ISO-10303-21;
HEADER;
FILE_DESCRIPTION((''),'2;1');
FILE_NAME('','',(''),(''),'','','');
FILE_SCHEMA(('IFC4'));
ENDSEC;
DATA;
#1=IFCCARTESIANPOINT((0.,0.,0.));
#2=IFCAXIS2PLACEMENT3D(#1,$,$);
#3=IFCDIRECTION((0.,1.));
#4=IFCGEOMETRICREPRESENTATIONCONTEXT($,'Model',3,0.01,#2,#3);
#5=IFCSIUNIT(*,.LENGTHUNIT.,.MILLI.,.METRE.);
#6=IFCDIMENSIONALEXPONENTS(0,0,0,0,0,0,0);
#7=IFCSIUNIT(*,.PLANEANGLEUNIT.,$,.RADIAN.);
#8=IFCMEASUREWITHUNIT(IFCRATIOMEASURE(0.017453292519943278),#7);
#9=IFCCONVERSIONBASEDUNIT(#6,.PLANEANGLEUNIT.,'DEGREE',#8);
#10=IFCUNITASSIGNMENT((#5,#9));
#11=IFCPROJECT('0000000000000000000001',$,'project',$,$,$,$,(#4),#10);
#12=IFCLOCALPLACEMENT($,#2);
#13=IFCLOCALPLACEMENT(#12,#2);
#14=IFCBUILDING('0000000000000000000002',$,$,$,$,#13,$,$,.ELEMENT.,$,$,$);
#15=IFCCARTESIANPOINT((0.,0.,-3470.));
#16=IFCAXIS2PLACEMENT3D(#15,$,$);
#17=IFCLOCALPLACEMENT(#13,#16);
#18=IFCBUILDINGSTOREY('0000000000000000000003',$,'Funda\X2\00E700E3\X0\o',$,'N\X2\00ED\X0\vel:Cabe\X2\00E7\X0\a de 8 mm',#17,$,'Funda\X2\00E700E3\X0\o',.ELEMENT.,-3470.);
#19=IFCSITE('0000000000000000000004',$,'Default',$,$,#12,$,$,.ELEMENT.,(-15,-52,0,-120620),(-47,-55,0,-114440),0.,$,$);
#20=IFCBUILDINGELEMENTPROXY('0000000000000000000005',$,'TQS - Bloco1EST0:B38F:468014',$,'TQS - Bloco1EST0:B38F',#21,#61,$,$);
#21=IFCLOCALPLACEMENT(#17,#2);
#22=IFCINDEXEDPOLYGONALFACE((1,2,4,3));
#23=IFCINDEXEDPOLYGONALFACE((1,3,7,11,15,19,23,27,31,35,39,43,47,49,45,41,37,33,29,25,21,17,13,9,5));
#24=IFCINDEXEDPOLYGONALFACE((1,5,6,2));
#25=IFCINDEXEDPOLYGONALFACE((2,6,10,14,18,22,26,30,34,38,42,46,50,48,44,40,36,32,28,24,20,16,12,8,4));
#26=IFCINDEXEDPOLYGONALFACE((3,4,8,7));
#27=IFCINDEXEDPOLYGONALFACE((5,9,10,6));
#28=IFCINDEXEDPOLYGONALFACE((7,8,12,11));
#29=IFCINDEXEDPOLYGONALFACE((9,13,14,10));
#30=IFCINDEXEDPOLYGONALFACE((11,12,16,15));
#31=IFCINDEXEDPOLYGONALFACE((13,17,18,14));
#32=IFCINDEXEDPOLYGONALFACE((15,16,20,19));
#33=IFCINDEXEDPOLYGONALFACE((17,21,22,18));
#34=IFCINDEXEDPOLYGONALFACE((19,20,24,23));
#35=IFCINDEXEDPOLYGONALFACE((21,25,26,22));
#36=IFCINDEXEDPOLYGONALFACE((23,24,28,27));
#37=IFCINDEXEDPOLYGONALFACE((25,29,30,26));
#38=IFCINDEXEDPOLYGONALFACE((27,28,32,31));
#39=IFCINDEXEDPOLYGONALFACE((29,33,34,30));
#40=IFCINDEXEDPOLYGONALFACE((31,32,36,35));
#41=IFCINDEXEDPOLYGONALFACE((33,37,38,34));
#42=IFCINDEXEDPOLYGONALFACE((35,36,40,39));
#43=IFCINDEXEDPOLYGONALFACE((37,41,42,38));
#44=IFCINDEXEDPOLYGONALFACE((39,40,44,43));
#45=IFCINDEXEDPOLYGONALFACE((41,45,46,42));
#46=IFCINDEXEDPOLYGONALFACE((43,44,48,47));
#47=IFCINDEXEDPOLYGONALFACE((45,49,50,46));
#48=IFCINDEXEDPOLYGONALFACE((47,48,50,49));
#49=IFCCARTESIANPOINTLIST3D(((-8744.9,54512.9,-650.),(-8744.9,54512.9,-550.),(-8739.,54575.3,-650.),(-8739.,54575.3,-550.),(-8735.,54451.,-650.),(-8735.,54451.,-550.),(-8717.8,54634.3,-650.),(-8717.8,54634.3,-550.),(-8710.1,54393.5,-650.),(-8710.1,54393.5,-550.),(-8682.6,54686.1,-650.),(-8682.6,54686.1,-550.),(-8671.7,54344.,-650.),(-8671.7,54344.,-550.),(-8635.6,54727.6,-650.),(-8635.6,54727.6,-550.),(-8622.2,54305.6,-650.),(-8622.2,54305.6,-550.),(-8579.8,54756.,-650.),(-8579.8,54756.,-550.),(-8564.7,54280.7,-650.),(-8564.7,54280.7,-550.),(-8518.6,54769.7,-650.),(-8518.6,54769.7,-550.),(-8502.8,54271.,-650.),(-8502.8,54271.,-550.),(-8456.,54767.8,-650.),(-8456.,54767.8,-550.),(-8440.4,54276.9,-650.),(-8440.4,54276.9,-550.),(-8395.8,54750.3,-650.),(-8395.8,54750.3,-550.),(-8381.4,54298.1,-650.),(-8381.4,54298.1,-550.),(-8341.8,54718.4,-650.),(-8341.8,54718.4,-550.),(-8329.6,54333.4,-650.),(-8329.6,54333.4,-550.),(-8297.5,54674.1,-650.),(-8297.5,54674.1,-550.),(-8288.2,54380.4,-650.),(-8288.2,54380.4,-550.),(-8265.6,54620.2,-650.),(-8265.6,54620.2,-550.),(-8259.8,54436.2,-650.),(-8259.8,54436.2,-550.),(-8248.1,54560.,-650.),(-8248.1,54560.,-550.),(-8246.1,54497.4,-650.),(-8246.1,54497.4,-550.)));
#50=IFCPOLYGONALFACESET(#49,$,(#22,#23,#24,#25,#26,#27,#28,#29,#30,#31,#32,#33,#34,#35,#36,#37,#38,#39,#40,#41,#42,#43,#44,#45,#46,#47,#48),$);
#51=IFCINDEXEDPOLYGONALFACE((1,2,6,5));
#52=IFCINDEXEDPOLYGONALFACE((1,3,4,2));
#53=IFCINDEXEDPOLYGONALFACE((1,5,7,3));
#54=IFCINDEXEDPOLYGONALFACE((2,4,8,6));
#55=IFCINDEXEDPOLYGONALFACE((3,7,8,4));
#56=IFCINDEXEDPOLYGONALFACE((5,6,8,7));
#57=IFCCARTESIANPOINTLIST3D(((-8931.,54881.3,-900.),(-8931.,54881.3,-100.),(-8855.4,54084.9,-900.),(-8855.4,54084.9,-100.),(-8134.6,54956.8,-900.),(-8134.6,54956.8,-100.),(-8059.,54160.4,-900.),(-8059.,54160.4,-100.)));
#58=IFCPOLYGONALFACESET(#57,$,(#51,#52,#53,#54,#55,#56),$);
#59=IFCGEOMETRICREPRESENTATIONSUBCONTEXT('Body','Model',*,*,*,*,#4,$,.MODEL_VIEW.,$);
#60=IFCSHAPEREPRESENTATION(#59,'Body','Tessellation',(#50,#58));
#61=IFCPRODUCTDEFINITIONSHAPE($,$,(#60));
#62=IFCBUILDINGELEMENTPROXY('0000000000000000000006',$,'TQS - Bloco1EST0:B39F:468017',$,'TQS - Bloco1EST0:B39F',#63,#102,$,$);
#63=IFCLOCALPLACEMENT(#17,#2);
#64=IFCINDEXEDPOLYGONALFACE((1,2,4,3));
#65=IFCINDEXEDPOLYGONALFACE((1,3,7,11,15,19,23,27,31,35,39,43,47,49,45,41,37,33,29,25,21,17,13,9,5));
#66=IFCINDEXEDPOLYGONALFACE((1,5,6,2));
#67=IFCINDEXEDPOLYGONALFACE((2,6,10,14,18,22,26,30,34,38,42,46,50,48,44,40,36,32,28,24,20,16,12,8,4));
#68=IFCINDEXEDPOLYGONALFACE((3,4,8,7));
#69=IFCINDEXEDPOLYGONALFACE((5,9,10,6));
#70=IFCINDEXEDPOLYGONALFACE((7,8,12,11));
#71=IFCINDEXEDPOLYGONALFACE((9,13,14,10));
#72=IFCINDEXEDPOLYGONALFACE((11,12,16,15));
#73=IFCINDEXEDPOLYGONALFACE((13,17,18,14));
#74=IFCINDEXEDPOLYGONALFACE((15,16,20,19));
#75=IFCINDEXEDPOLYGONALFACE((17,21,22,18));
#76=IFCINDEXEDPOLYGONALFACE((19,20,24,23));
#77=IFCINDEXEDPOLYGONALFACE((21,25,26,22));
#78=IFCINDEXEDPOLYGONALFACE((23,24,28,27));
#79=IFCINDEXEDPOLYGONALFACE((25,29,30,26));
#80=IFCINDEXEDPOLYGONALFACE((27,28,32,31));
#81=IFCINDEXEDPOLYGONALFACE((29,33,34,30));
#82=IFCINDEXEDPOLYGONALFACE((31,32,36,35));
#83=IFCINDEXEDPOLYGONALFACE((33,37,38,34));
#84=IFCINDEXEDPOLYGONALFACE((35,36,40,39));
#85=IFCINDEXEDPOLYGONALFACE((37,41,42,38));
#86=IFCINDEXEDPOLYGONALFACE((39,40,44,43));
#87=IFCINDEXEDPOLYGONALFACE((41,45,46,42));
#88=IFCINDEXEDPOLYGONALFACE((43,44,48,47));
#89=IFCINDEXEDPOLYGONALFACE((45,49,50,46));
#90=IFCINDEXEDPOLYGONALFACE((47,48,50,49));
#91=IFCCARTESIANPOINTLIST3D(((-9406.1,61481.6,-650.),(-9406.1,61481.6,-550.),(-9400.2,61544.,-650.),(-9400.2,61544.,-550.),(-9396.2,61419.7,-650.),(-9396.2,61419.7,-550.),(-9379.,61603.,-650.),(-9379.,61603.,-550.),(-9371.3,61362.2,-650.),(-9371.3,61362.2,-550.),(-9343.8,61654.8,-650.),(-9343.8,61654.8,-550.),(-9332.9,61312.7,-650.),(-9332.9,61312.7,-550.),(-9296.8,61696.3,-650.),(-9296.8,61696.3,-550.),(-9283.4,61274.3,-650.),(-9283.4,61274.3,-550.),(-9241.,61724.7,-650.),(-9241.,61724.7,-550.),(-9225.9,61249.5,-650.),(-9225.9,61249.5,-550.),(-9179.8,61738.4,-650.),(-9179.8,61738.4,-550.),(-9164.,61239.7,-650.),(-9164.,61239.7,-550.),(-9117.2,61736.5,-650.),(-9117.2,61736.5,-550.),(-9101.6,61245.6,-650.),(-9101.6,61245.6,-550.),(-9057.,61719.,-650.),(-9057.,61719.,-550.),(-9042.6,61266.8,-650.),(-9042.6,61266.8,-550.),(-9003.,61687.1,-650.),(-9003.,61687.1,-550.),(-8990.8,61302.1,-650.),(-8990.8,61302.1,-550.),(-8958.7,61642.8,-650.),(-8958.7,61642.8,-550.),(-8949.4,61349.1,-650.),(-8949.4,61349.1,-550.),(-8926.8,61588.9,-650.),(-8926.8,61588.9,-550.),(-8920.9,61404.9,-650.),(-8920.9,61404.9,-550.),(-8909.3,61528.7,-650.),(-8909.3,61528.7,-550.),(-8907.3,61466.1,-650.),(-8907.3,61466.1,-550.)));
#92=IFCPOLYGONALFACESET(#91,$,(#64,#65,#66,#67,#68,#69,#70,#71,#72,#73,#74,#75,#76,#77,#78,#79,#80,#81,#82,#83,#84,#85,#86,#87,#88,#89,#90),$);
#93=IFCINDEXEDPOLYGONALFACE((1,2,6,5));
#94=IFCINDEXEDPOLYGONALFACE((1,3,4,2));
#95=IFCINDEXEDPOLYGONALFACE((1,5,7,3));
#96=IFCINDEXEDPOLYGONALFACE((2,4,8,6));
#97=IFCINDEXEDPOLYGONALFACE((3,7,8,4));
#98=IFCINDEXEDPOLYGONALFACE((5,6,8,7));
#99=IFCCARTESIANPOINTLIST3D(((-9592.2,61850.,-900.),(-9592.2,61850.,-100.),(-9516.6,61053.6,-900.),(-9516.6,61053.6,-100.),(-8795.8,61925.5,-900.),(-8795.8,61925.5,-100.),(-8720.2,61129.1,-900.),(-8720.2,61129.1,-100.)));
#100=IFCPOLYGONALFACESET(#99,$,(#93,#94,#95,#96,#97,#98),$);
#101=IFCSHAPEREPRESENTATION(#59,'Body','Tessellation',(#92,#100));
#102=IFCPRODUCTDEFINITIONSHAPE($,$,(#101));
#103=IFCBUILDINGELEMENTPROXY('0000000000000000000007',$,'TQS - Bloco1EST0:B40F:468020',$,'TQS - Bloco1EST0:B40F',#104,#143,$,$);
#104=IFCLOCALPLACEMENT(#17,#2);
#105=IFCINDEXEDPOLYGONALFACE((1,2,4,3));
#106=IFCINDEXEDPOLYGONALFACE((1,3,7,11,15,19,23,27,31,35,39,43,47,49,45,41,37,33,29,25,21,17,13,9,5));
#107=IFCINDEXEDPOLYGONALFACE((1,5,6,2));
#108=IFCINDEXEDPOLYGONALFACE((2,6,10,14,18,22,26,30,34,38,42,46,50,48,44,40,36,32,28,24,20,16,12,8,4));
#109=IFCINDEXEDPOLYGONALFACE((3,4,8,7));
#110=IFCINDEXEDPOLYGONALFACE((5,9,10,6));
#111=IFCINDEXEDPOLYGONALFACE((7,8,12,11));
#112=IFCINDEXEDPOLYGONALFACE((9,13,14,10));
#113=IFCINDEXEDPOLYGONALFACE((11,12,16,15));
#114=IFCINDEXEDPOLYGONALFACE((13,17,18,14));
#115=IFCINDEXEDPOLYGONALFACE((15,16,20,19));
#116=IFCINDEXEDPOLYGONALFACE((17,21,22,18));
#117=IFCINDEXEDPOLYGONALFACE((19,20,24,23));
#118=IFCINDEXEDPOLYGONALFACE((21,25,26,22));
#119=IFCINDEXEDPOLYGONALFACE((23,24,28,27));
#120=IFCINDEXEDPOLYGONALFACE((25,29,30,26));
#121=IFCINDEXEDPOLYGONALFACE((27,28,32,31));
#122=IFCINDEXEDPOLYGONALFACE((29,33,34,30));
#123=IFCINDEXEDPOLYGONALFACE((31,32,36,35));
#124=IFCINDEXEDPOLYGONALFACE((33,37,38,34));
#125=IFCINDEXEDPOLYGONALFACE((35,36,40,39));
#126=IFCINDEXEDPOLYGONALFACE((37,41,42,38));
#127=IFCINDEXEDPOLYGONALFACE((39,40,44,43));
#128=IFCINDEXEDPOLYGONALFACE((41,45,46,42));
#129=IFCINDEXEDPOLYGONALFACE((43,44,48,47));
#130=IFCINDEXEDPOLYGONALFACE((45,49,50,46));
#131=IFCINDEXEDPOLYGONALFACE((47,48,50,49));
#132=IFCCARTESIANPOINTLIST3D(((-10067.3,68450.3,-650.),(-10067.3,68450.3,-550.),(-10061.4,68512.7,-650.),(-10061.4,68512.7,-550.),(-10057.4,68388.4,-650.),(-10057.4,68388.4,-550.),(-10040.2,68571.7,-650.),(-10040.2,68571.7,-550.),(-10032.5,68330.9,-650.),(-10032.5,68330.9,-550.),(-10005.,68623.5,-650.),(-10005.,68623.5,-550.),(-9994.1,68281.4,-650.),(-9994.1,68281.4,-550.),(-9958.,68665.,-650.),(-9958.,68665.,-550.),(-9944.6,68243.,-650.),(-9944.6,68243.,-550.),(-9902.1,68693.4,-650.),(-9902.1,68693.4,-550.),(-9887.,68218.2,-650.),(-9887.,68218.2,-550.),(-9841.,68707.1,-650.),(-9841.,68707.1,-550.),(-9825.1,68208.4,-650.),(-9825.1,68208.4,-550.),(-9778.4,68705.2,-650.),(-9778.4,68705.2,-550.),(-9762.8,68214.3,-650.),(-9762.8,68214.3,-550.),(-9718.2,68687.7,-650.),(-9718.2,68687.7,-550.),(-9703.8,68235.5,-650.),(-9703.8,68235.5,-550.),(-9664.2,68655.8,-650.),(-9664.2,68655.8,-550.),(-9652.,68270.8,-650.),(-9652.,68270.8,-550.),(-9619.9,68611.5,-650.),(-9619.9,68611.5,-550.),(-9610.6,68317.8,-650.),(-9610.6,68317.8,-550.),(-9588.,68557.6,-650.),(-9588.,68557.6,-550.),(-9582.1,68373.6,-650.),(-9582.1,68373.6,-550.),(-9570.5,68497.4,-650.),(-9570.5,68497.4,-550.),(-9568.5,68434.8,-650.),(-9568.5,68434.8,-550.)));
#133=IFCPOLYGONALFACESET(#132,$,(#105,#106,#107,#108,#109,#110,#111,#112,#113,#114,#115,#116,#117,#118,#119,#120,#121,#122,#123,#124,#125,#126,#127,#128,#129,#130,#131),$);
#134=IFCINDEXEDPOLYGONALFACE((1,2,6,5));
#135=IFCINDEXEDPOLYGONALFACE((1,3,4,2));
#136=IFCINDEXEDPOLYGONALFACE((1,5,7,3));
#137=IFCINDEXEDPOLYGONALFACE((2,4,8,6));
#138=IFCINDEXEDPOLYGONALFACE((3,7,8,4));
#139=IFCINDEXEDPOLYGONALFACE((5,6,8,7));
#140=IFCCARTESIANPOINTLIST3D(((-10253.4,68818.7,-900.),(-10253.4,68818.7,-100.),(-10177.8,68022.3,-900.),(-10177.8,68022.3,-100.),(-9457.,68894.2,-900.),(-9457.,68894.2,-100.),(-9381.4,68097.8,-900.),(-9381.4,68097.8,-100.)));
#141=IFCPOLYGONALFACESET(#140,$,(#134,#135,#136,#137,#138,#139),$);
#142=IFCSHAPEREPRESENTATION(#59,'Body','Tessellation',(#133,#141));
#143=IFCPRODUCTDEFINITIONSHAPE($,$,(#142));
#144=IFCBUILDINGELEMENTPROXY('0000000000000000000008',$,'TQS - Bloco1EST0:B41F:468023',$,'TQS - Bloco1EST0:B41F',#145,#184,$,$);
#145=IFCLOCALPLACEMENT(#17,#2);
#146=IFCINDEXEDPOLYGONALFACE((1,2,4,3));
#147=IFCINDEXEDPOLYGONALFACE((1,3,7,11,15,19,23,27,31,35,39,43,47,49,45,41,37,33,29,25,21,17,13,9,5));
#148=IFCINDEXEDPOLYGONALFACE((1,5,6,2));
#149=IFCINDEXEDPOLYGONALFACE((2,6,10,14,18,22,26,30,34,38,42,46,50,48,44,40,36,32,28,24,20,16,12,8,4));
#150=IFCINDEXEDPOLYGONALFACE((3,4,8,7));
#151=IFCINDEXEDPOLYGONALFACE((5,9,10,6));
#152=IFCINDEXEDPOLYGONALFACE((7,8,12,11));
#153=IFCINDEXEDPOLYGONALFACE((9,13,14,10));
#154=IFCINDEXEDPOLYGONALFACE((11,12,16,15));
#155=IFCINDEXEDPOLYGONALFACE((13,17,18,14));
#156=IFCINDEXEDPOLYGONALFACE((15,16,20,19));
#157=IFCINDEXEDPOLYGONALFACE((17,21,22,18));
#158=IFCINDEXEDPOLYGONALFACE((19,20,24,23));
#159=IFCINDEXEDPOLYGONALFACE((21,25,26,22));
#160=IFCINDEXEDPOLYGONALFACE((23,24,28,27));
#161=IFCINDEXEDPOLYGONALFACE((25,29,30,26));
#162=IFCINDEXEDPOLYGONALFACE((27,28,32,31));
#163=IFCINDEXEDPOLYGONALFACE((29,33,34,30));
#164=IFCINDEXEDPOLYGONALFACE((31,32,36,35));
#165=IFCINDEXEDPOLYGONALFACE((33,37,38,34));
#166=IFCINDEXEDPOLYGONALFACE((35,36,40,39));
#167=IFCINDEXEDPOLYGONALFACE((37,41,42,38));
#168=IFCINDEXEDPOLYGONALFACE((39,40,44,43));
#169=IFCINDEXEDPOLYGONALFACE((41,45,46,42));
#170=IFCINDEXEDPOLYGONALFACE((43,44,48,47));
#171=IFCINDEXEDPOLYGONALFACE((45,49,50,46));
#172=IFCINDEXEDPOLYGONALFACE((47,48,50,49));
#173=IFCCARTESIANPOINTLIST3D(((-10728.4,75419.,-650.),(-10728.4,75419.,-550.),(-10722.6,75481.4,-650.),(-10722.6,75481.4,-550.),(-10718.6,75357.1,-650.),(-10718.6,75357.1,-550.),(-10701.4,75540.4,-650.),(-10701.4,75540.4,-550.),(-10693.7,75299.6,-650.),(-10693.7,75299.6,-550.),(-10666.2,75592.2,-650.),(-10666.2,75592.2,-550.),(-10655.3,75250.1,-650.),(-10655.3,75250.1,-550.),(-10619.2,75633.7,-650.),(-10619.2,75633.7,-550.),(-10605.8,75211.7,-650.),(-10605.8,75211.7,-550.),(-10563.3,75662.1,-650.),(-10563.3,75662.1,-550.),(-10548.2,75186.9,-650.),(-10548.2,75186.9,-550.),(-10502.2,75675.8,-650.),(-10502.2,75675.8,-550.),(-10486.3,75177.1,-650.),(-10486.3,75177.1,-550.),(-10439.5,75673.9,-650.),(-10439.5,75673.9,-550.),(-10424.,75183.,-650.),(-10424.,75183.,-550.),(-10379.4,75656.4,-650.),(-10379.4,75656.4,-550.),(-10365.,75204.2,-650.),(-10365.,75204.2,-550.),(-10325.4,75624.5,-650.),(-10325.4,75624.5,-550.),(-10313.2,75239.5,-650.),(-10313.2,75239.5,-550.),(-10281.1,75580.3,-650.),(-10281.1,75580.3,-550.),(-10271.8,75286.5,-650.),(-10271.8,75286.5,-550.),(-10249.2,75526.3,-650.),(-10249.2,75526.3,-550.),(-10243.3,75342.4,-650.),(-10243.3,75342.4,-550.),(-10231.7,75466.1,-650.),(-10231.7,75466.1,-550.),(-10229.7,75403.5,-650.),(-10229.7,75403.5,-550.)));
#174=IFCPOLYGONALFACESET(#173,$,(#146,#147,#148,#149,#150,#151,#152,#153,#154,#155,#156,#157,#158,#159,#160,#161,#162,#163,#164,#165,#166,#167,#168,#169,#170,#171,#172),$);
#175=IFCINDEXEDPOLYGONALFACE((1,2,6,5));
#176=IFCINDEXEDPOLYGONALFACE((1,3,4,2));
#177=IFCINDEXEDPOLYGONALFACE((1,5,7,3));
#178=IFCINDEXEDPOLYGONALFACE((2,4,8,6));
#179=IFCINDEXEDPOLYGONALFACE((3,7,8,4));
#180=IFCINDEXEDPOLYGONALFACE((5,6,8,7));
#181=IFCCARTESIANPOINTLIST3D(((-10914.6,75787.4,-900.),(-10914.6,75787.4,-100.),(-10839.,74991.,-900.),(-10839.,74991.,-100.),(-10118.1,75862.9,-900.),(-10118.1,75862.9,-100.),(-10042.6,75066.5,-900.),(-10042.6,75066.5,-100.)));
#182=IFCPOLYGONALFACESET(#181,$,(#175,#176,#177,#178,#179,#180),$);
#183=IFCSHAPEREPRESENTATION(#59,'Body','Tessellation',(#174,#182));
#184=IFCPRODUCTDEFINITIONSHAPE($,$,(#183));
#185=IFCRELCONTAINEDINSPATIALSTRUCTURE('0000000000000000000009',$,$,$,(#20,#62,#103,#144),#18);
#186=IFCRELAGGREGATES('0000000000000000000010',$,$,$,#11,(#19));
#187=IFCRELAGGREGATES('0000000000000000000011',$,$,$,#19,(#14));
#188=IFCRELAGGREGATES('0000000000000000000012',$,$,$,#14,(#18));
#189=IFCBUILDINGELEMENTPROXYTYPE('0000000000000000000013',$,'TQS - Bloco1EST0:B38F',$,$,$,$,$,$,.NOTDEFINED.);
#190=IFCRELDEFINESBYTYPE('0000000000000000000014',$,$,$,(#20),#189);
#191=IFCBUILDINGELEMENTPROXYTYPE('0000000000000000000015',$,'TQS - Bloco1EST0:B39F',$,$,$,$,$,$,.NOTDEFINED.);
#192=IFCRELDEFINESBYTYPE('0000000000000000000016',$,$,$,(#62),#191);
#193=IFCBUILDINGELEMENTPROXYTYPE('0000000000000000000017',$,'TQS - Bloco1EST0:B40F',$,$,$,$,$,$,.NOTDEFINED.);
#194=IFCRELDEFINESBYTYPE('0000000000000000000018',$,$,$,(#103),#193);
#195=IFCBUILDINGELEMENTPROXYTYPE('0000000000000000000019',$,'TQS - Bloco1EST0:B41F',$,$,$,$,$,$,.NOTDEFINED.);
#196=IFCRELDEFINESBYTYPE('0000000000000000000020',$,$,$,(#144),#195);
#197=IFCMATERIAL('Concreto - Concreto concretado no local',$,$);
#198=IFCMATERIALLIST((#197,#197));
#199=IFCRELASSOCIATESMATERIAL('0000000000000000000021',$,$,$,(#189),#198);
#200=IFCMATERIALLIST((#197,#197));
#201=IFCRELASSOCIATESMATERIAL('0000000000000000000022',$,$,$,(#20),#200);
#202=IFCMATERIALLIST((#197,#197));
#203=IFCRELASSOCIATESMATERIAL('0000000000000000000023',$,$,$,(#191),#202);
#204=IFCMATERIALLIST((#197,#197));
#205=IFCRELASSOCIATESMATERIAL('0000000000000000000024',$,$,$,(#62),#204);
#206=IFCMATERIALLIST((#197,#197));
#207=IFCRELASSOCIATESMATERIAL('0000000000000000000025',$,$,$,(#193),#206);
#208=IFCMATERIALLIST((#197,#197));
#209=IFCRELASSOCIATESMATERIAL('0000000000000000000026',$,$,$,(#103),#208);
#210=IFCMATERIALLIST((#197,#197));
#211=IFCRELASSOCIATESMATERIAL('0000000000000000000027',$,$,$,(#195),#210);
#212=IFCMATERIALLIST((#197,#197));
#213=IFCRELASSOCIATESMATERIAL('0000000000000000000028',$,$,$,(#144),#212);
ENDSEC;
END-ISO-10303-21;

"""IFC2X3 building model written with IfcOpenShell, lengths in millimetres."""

from ifc_helpers import new_model, entity, si_unit, converted_unit, direction, frame, frame_2d, origin, origin_2d_with_axis, place, context, subcontext, project, spatial, rectangle, circle, extrude, source, transform, mapped, material, material_list, type_object, type_shapes, element, save


model = new_model("IFC2X3")

# Units and contexts
model_context = context("Model", 3, precision=0.01, world=origin(), true_north=direction((0.0, 1.0)))
body_context = subcontext(model_context, "Body", "Model", "MODEL_VIEW")
ifc_project = project(units=[si_unit("LENGTHUNIT", "METRE", prefix="MILLI"), converted_unit("PLANEANGLEUNIT", "DEGREE", entity("IfcRatioMeasure", 0.017453292519943278), si_unit("PLANEANGLEUNIT", "RADIAN"), dimensions=[0, 0, 0, 0, 0, 0, 0])], contexts=[model_context])

# Site, building, storey
site_placement = place(None, origin())
site = spatial("IfcSite", under=ifc_project, at=site_placement, Name="Default", CompositionType="ELEMENT", RefLatitude=(-15, -52, 0, -120620), RefLongitude=(-47, -55, 0, -114440), RefElevation=0.0)
building_placement = place(site_placement, origin())
building = spatial("IfcBuilding", under=site, at=building_placement, CompositionType="ELEMENT")
storey_placement = place(building_placement, frame((0.0, 0.0, -3470.0)))
storey = spatial("IfcBuildingStorey", under=building, at=storey_placement, Name="Fundação", ObjectType="Nível:Cabeça de 8 mm", LongName="Fundação", CompositionType="ELEMENT", Elevation=-3470.0)

# Building element proxies
ifc_material_1 = material(Name="Concreto - Concreto concretado no local")
ifc_material_list_1 = material_list([ifc_material_1, ifc_material_1])
ifc_material_list_2 = material_list([ifc_material_1, ifc_material_1])
building_element_proxy_type_1 = type_object("IfcBuildingElementProxyType", Name="TQS - Bloco1EST0:B38F", PredefinedType="NOTDEFINED", material=ifc_material_list_2)
shared_shape_1 = source(origin(), body_context, "Body", "SweptSolid", [
    extrude(circle(Radius=250.0, at=frame_2d((0.0, 0.0), x_axis=(1.0, 0.0))), frame((0.0, 0.0, -550.0)), (0.0, 0.0, 1.0), 100.0),
    extrude(rectangle(XDim=800.0, YDim=800.0, at=origin_2d_with_axis()), frame((0.0, 0.0, -800.0), z_axis=(0.0, 0.0, 1.0), x_axis=(-1.0, 0.0, 0.0)), (0.0, 0.0, 1.0), 800.0),
])
type_shapes(building_element_proxy_type_1, [shared_shape_1])
proxy_1_placement = place(storey_placement, frame((-8495.0, 54520.8, -100.0), z_axis=(0.0, 0.0, 1.0), x_axis=(-0.094456, 0.995529, 0.0)))
element("IfcBuildingElementProxy", 1, at=proxy_1_placement, inside=storey, type_object=building_element_proxy_type_1, material=ifc_material_list_1, Name="TQS - Bloco1EST0:B38F:468014", ObjectType="TQS - Bloco1EST0:B38F", context=body_context, shape_type="MappedRepresentation", body=[
    mapped(shared_shape_1, transform((0.0, 0.0, 0.0), scale=1.0)),
])
ifc_material_list_3 = material_list([ifc_material_1, ifc_material_1])
ifc_material_list_4 = material_list([ifc_material_1, ifc_material_1])
building_element_proxy_type_2 = type_object("IfcBuildingElementProxyType", Name="TQS - Bloco1EST0:B39F", PredefinedType="NOTDEFINED", material=ifc_material_list_4)
shared_shape_2 = source(origin(), body_context, "Body", "SweptSolid", [
    extrude(circle(Radius=250.0, at=frame_2d((0.0, 0.0), x_axis=(1.0, 0.0))), frame((0.0, 0.0, -550.0)), (0.0, 0.0, 1.0), 100.0),
    extrude(rectangle(XDim=800.0, YDim=800.0, at=origin_2d_with_axis()), frame((0.0, 0.0, -800.0), z_axis=(0.0, 0.0, 1.0), x_axis=(-1.0, 0.0, 0.0)), (0.0, 0.0, 1.0), 800.0),
])
type_shapes(building_element_proxy_type_2, [shared_shape_2])
proxy_2_placement = place(storey_placement, frame((-9156.2, 61489.5, -100.0), z_axis=(0.0, 0.0, 1.0), x_axis=(-0.094456, 0.995529, 0.0)))
element("IfcBuildingElementProxy", 2, at=proxy_2_placement, inside=storey, type_object=building_element_proxy_type_2, material=ifc_material_list_3, Name="TQS - Bloco1EST0:B39F:468017", ObjectType="TQS - Bloco1EST0:B39F", context=body_context, shape_type="MappedRepresentation", body=[
    mapped(shared_shape_2, transform((0.0, 0.0, 0.0), scale=1.0)),
])
ifc_material_list_5 = material_list([ifc_material_1, ifc_material_1])
ifc_material_list_6 = material_list([ifc_material_1, ifc_material_1])
building_element_proxy_type_3 = type_object("IfcBuildingElementProxyType", Name="TQS - Bloco1EST0:B40F", PredefinedType="NOTDEFINED", material=ifc_material_list_6)
shared_shape_3 = source(origin(), body_context, "Body", "SweptSolid", [
    extrude(circle(Radius=250.0, at=frame_2d((0.0, 0.0), x_axis=(1.0, 0.0))), frame((0.0, 0.0, -550.0)), (0.0, 0.0, 1.0), 100.0),
    extrude(rectangle(XDim=800.0, YDim=800.0, at=origin_2d_with_axis()), frame((0.0, 0.0, -800.0), z_axis=(0.0, 0.0, 1.0), x_axis=(-1.0, 0.0, 0.0)), (0.0, 0.0, 1.0), 800.0),
])
type_shapes(building_element_proxy_type_3, [shared_shape_3])
proxy_3_placement = place(storey_placement, frame((-9817.4, 68458.3, -100.0), z_axis=(0.0, 0.0, 1.0), x_axis=(-0.094456, 0.995529, 0.0)))
element("IfcBuildingElementProxy", 3, at=proxy_3_placement, inside=storey, type_object=building_element_proxy_type_3, material=ifc_material_list_5, Name="TQS - Bloco1EST0:B40F:468020", ObjectType="TQS - Bloco1EST0:B40F", context=body_context, shape_type="MappedRepresentation", body=[
    mapped(shared_shape_3, transform((0.0, 0.0, 0.0), scale=1.0)),
])
ifc_material_list_7 = material_list([ifc_material_1, ifc_material_1])
ifc_material_list_8 = material_list([ifc_material_1, ifc_material_1])
building_element_proxy_type_4 = type_object("IfcBuildingElementProxyType", Name="TQS - Bloco1EST0:B41F", PredefinedType="NOTDEFINED", material=ifc_material_list_8)
shared_shape_4 = source(origin(), body_context, "Body", "SweptSolid", [
    extrude(circle(Radius=250.0, at=frame_2d((0.0, 0.0), x_axis=(1.0, 0.0))), frame((0.0, 0.0, -550.0)), (0.0, 0.0, 1.0), 100.0),
    extrude(rectangle(XDim=800.0, YDim=800.0, at=origin_2d_with_axis()), frame((0.0, 0.0, -800.0), z_axis=(0.0, 0.0, 1.0), x_axis=(-1.0, 0.0, 0.0)), (0.0, 0.0, 1.0), 800.0),
])
type_shapes(building_element_proxy_type_4, [shared_shape_4])
proxy_4_placement = place(storey_placement, frame((-10478.6, 75427.0, -100.0), z_axis=(0.0, 0.0, 1.0), x_axis=(-0.094456, 0.995529, 0.0)))
element("IfcBuildingElementProxy", 4, at=proxy_4_placement, inside=storey, type_object=building_element_proxy_type_4, material=ifc_material_list_7, Name="TQS - Bloco1EST0:B41F:468023", ObjectType="TQS - Bloco1EST0:B41F", context=body_context, shape_type="MappedRepresentation", body=[
    mapped(shared_shape_4, transform((0.0, 0.0, 0.0), scale=1.0)),
])

save(model, "model.ifc")
